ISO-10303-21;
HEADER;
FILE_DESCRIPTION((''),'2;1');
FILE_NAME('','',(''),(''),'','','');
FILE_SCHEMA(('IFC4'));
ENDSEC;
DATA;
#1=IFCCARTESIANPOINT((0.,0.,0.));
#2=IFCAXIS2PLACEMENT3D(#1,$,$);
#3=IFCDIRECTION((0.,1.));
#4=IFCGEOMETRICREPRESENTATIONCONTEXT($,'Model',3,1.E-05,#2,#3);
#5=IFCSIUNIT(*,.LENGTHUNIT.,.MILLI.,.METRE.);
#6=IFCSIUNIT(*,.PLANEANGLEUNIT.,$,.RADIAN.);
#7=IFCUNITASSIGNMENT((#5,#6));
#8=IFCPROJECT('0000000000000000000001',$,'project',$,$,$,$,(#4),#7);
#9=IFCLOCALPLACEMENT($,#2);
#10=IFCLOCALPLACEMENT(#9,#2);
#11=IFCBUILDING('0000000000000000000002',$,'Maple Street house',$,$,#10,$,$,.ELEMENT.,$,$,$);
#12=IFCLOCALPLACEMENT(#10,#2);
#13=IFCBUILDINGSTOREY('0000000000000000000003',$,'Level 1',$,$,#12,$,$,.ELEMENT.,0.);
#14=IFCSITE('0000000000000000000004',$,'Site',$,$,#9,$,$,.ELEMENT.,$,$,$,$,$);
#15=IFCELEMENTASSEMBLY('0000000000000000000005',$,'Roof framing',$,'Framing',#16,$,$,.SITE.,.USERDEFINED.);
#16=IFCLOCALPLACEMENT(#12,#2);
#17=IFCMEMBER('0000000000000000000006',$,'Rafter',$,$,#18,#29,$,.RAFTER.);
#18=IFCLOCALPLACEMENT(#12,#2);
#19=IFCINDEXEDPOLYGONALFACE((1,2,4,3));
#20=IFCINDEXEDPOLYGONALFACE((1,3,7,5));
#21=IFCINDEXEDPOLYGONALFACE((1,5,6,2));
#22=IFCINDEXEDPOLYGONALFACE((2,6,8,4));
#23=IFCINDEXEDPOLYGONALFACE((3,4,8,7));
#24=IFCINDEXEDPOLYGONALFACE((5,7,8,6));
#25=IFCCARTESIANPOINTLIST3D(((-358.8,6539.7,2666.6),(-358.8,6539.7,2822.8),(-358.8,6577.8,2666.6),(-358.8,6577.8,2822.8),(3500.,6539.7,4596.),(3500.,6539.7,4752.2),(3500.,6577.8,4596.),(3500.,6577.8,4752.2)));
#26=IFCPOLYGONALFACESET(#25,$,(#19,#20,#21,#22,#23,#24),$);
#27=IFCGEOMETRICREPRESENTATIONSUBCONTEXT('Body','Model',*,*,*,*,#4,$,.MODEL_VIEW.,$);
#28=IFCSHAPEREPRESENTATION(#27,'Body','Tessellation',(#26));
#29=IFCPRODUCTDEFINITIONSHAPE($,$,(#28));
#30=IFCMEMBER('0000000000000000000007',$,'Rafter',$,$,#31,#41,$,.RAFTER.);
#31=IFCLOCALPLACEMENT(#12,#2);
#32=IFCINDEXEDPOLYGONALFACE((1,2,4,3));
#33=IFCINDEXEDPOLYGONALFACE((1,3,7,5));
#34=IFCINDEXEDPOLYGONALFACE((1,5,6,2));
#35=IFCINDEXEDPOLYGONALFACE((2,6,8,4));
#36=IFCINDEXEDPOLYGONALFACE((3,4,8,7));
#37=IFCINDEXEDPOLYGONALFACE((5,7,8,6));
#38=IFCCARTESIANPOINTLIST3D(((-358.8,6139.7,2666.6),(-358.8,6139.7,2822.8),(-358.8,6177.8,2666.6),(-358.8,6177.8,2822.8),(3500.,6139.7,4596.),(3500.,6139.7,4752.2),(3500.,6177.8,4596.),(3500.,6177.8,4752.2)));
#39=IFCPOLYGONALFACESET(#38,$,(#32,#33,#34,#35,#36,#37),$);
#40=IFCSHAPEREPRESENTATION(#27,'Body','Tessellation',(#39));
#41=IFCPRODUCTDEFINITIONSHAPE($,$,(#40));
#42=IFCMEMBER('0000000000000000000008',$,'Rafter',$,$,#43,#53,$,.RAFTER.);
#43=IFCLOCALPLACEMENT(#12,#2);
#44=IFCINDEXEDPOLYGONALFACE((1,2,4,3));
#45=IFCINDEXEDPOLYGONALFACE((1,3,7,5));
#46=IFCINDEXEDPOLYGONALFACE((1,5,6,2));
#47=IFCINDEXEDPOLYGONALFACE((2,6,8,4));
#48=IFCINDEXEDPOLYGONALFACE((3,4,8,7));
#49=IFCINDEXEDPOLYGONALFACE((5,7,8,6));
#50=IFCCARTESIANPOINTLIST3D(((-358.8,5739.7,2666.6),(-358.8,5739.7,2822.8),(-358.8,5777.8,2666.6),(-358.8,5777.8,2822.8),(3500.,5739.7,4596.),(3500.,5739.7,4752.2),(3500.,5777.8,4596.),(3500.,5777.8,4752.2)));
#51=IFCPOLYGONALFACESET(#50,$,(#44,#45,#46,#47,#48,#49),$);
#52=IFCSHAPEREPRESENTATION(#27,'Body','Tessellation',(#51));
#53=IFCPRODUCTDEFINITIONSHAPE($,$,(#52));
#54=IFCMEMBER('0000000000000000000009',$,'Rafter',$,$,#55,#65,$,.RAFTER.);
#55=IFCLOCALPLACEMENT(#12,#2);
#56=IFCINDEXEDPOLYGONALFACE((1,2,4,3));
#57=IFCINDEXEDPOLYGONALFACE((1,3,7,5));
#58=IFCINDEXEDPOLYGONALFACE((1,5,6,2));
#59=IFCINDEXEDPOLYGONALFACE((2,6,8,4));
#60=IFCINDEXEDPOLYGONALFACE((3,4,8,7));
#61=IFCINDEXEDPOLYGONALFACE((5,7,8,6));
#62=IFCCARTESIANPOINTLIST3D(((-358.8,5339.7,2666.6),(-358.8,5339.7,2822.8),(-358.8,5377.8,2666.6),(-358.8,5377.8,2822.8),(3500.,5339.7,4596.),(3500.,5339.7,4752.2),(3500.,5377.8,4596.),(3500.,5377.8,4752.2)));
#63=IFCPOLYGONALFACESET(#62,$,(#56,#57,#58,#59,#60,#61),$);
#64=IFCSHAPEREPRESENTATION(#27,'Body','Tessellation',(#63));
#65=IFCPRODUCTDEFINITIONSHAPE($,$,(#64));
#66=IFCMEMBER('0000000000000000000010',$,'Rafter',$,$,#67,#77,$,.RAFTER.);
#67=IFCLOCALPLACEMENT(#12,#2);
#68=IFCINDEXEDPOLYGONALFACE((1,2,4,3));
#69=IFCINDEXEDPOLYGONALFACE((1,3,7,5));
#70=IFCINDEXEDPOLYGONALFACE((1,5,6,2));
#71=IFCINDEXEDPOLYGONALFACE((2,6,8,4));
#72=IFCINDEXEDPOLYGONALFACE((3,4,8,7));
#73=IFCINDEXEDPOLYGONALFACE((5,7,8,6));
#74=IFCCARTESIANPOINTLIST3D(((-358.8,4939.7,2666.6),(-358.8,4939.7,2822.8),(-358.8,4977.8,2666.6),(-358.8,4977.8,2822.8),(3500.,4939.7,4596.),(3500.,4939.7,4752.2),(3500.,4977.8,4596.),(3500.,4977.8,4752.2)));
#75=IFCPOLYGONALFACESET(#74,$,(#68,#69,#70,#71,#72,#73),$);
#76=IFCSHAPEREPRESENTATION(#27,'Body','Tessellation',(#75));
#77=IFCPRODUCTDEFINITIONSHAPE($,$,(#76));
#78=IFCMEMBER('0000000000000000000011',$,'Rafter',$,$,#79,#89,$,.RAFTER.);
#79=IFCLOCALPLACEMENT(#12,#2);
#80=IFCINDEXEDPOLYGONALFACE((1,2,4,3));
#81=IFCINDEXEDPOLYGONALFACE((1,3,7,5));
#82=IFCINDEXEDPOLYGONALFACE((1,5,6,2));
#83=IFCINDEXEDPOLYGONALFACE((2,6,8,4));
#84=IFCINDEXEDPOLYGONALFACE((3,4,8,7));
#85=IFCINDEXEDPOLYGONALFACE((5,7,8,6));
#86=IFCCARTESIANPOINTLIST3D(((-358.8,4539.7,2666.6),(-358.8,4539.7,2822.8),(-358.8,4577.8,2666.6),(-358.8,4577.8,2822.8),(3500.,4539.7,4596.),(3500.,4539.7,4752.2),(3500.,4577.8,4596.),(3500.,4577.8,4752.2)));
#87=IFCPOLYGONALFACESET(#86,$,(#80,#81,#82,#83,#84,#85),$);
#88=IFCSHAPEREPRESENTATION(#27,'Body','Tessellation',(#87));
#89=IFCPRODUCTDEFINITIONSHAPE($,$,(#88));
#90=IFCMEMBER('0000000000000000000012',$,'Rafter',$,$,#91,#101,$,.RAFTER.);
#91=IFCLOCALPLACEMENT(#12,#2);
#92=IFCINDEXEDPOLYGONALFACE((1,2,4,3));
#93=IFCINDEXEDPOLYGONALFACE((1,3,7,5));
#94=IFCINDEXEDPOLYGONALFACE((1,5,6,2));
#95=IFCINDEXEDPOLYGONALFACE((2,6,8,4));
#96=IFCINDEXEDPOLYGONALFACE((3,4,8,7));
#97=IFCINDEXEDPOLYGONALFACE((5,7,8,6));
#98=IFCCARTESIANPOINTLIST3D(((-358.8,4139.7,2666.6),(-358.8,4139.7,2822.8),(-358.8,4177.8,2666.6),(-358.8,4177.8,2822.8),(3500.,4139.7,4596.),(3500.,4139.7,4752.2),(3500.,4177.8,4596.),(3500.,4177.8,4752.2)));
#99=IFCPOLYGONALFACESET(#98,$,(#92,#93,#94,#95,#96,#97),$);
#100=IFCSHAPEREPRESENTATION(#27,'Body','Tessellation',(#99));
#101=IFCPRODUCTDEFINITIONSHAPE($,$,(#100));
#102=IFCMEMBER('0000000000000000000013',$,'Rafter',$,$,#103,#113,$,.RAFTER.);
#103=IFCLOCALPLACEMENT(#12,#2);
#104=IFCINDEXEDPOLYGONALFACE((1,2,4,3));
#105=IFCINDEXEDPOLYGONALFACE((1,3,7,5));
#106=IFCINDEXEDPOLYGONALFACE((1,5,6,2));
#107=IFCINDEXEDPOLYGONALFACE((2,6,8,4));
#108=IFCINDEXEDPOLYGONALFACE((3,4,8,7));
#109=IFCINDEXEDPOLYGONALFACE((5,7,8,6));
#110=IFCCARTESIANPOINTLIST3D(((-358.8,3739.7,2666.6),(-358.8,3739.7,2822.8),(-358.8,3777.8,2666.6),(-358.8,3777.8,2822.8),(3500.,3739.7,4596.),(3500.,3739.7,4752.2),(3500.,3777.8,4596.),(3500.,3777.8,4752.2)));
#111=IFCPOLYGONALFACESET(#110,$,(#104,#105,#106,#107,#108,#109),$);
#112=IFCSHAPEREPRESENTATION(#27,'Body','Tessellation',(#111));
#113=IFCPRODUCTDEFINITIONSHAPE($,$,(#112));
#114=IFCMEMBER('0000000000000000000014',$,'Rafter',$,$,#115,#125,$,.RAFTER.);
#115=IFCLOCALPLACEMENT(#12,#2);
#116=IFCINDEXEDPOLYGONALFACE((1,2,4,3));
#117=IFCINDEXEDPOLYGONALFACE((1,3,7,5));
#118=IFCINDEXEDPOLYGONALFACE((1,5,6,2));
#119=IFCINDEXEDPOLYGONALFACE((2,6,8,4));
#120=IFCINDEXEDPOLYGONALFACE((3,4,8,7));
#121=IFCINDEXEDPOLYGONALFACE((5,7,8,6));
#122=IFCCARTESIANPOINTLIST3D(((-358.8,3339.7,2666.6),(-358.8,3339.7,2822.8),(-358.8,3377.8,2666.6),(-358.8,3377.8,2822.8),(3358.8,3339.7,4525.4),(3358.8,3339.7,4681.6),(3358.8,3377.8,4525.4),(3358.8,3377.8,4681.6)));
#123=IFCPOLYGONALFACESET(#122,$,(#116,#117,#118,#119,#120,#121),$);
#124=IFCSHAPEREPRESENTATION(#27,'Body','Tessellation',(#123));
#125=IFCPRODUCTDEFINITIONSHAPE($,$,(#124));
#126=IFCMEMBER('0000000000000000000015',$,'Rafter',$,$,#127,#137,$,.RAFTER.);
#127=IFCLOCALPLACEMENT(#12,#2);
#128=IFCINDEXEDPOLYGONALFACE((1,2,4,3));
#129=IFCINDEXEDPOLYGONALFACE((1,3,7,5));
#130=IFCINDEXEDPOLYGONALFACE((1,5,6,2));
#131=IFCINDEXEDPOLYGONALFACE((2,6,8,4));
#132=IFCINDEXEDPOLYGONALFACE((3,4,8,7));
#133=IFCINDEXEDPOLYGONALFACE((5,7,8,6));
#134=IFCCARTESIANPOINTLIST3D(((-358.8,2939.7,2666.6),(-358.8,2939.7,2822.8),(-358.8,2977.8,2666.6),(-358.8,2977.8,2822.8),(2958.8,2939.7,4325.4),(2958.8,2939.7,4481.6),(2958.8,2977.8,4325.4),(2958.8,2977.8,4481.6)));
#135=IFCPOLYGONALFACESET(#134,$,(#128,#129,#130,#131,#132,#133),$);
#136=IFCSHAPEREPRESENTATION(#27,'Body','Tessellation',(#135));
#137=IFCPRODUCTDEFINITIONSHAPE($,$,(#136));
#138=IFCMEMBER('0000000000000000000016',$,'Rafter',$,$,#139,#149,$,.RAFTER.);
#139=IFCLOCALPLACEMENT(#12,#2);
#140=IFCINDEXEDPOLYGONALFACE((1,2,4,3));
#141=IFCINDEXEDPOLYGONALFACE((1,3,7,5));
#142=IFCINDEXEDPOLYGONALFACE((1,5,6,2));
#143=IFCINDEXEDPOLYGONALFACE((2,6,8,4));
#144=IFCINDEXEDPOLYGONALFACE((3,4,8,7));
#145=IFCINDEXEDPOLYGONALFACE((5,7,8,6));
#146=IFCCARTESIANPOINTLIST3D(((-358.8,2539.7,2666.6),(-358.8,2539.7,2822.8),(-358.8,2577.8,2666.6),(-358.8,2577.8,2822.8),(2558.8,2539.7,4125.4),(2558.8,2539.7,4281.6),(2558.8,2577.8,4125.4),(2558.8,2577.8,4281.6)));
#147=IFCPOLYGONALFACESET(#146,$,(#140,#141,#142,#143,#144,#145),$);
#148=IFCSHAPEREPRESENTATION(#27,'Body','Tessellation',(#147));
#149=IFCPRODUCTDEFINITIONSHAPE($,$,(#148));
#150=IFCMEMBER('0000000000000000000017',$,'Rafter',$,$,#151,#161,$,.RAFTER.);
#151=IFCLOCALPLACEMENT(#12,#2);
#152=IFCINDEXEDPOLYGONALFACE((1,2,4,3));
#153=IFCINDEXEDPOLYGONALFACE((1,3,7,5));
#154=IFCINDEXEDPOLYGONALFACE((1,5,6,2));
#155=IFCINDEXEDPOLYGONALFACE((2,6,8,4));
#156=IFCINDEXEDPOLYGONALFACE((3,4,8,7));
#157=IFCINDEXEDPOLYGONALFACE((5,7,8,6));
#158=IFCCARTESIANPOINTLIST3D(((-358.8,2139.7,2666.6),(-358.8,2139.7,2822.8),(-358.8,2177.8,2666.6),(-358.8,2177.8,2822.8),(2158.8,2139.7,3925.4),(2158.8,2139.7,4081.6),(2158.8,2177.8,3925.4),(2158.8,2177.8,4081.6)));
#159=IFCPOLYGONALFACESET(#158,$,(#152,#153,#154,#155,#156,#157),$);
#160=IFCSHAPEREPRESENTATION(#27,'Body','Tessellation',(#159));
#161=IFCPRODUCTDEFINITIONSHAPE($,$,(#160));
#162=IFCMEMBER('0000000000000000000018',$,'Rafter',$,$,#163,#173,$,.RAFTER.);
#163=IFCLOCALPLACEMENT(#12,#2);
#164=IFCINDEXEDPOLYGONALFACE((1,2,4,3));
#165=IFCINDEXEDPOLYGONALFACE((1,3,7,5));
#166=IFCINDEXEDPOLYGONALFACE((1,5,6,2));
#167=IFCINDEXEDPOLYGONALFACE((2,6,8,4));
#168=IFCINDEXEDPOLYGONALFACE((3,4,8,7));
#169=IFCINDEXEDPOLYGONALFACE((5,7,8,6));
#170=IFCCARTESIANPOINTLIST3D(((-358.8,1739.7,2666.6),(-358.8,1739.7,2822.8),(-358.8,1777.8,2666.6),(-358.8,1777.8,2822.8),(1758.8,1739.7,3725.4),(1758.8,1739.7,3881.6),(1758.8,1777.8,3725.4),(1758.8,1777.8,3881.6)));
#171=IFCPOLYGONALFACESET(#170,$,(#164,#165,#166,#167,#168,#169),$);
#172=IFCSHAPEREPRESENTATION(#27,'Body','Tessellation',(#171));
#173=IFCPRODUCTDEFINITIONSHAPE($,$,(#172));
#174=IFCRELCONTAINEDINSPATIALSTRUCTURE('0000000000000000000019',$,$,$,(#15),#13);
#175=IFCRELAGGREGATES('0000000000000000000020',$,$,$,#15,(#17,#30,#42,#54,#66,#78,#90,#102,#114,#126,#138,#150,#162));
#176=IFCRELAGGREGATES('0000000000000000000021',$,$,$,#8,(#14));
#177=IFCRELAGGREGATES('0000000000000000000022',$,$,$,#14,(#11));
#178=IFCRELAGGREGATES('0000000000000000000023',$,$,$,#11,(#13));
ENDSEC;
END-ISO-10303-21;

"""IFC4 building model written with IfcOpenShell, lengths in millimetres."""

from ifc_helpers import new_model, si_unit, direction, frame, origin, origin_with_axes, place, context, subcontext, project, spatial, polyline, outline, extrude, element, aggregate, save


model = new_model("IFC4")

# Units and contexts
model_context = context("Model", 3, precision=1e-05, world=origin(), true_north=direction((0.0, 1.0)))
body_context = subcontext(model_context, "Body", "Model", "MODEL_VIEW")
ifc_project = project(units=[si_unit("LENGTHUNIT", "METRE", prefix="MILLI"), si_unit("PLANEANGLEUNIT", "RADIAN")], contexts=[model_context])

# Site, building, storey
site_placement = place(None, origin())
site = spatial("IfcSite", under=ifc_project, at=site_placement, Name="Site", CompositionType="ELEMENT")
building_placement = place(site_placement, origin())
building = spatial("IfcBuilding", under=site, at=building_placement, Name="Maple Street house", CompositionType="ELEMENT")
storey_placement = place(building_placement, origin())
storey = spatial("IfcBuildingStorey", under=building, at=storey_placement, Name="Level 1", CompositionType="ELEMENT", Elevation=0.0)

# Element assembly, members
assembly_placement = place(storey_placement, origin_with_axes())
assembly = element("IfcElementAssembly", 1, at=assembly_placement, inside=storey, Name="Roof framing", ObjectType="Framing", AssemblyPlace="SITE", PredefinedType="USERDEFINED")
member_1_placement = place(storey_placement, origin_with_axes())
member_1 = element("IfcMember", 2, at=member_1_placement, Name="Rafter", PredefinedType="RAFTER", context=body_context, shape_type="SweptSolid", body=[
    extrude(outline(polyline([(0.0, 0.0), (38.1, 0.0), (38.1, 156.2), (0.0, 156.2), (0.0, 0.0)])), frame((-358.8, 6539.7, 2666.7), z_axis=(1.0, 0.0, 0.0), x_axis=(0.0, 1.0, 0.0)), (0.0, 0.447214, 0.894427), 4314.2),
])
member_2_placement = place(storey_placement, origin_with_axes())
member_2 = element("IfcMember", 3, at=member_2_placement, Name="Rafter", PredefinedType="RAFTER", context=body_context, shape_type="SweptSolid", body=[
    extrude(outline(polyline([(0.0, 0.0), (38.1, 0.0), (38.1, 156.2), (0.0, 156.2), (0.0, 0.0)])), frame((-358.8, 6139.7, 2666.7), z_axis=(1.0, 0.0, 0.0), x_axis=(0.0, 1.0, 0.0)), (0.0, 0.447214, 0.894427), 4314.2),
])
member_3_placement = place(storey_placement, origin_with_axes())
member_3 = element("IfcMember", 4, at=member_3_placement, Name="Rafter", PredefinedType="RAFTER", context=body_context, shape_type="SweptSolid", body=[
    extrude(outline(polyline([(0.0, 0.0), (38.1, 0.0), (38.1, 156.2), (0.0, 156.2), (0.0, 0.0)])), frame((-358.8, 5739.7, 2666.7), z_axis=(1.0, 0.0, 0.0), x_axis=(0.0, 1.0, 0.0)), (0.0, 0.447214, 0.894427), 4314.2),
])
member_4_placement = place(storey_placement, origin_with_axes())
member_4 = element("IfcMember", 5, at=member_4_placement, Name="Rafter", PredefinedType="RAFTER", context=body_context, shape_type="SweptSolid", body=[
    extrude(outline(polyline([(0.0, 0.0), (38.1, 0.0), (38.1, 156.2), (0.0, 156.2), (0.0, 0.0)])), frame((-358.8, 5339.7, 2666.7), z_axis=(1.0, 0.0, 0.0), x_axis=(0.0, 1.0, 0.0)), (0.0, 0.447214, 0.894427), 4314.2),
])
member_5_placement = place(storey_placement, origin_with_axes())
member_5 = element("IfcMember", 6, at=member_5_placement, Name="Rafter", PredefinedType="RAFTER", context=body_context, shape_type="SweptSolid", body=[
    extrude(outline(polyline([(0.0, 0.0), (38.1, 0.0), (38.1, 156.2), (0.0, 156.2), (0.0, 0.0)])), frame((-358.8, 4939.7, 2666.7), z_axis=(1.0, 0.0, 0.0), x_axis=(0.0, 1.0, 0.0)), (0.0, 0.447214, 0.894427), 4314.2),
])
member_6_placement = place(storey_placement, origin_with_axes())
member_6 = element("IfcMember", 7, at=member_6_placement, Name="Rafter", PredefinedType="RAFTER", context=body_context, shape_type="SweptSolid", body=[
    extrude(outline(polyline([(0.0, 0.0), (38.1, 0.0), (38.1, 156.2), (0.0, 156.2), (0.0, 0.0)])), frame((-358.8, 4539.7, 2666.7), z_axis=(1.0, 0.0, 0.0), x_axis=(0.0, 1.0, 0.0)), (0.0, 0.447214, 0.894427), 4314.2),
])
member_7_placement = place(storey_placement, origin_with_axes())
member_7 = element("IfcMember", 8, at=member_7_placement, Name="Rafter", PredefinedType="RAFTER", context=body_context, shape_type="SweptSolid", body=[
    extrude(outline(polyline([(0.0, 0.0), (38.1, 0.0), (38.1, 156.2), (0.0, 156.2), (0.0, 0.0)])), frame((-358.8, 4139.7, 2666.7), z_axis=(1.0, 0.0, 0.0), x_axis=(0.0, 1.0, 0.0)), (0.0, 0.447214, 0.894427), 4314.2),
])
member_8_placement = place(storey_placement, origin_with_axes())
member_8 = element("IfcMember", 9, at=member_8_placement, Name="Rafter", PredefinedType="RAFTER", context=body_context, shape_type="SweptSolid", body=[
    extrude(outline(polyline([(0.0, 0.0), (38.1, 0.0), (38.1, 156.2), (0.0, 156.2), (0.0, 0.0)])), frame((-358.8, 3739.7, 2666.7), z_axis=(1.0, 0.0, 0.0), x_axis=(0.0, 1.0, 0.0)), (0.0, 0.447214, 0.894427), 4314.2),
])
member_9_placement = place(storey_placement, origin_with_axes())
member_9 = element("IfcMember", 10, at=member_9_placement, Name="Rafter", PredefinedType="RAFTER", context=body_context, shape_type="SweptSolid", body=[
    extrude(outline(polyline([(0.0, 0.0), (38.1, 0.0), (38.1, 156.2), (0.0, 156.2), (0.0, 0.0)])), frame((-358.8, 3339.7, 2666.7), z_axis=(1.0, 0.0, 0.0), x_axis=(0.0, 1.0, 0.0)), (0.0, 0.447214, 0.894427), 4156.3),
])
member_10_placement = place(storey_placement, origin_with_axes())
member_10 = element("IfcMember", 11, at=member_10_placement, Name="Rafter", PredefinedType="RAFTER", context=body_context, shape_type="SweptSolid", body=[
    extrude(outline(polyline([(0.0, 0.0), (38.1, 0.0), (38.1, 156.2), (0.0, 156.2), (0.0, 0.0)])), frame((-358.8, 2939.7, 2666.7), z_axis=(1.0, 0.0, 0.0), x_axis=(0.0, 1.0, 0.0)), (0.0, 0.447214, 0.894427), 3709.1),
])
member_11_placement = place(storey_placement, origin_with_axes())
member_11 = element("IfcMember", 12, at=member_11_placement, Name="Rafter", PredefinedType="RAFTER", context=body_context, shape_type="SweptSolid", body=[
    extrude(outline(polyline([(0.0, 0.0), (38.1, 0.0), (38.1, 156.2), (0.0, 156.2), (0.0, 0.0)])), frame((-358.8, 2539.7, 2666.7), z_axis=(1.0, 0.0, 0.0), x_axis=(0.0, 1.0, 0.0)), (0.0, 0.447214, 0.894427), 3261.9),
])
member_12_placement = place(storey_placement, origin_with_axes())
member_12 = element("IfcMember", 13, at=member_12_placement, Name="Rafter", PredefinedType="RAFTER", context=body_context, shape_type="SweptSolid", body=[
    extrude(outline(polyline([(0.0, 0.0), (38.1, 0.0), (38.1, 156.2), (0.0, 156.2), (0.0, 0.0)])), frame((-358.8, 2139.7, 2666.7), z_axis=(1.0, 0.0, 0.0), x_axis=(0.0, 1.0, 0.0)), (0.0, 0.447214, 0.894427), 2814.7),
])
member_13_placement = place(storey_placement, origin_with_axes())
member_13 = element("IfcMember", 14, at=member_13_placement, Name="Rafter", PredefinedType="RAFTER", context=body_context, shape_type="SweptSolid", body=[
    extrude(outline(polyline([(0.0, 0.0), (38.1, 0.0), (38.1, 156.2), (0.0, 156.2), (0.0, 0.0)])), frame((-358.8, 1739.7, 2666.7), z_axis=(1.0, 0.0, 0.0), x_axis=(0.0, 1.0, 0.0)), (0.0, 0.447214, 0.894427), 2367.5),
])
aggregate(assembly, [member_1, member_2, member_3, member_4, member_5, member_6, member_7, member_8, member_9, member_10, member_11, member_12, member_13])

save(model, "model.ifc")
